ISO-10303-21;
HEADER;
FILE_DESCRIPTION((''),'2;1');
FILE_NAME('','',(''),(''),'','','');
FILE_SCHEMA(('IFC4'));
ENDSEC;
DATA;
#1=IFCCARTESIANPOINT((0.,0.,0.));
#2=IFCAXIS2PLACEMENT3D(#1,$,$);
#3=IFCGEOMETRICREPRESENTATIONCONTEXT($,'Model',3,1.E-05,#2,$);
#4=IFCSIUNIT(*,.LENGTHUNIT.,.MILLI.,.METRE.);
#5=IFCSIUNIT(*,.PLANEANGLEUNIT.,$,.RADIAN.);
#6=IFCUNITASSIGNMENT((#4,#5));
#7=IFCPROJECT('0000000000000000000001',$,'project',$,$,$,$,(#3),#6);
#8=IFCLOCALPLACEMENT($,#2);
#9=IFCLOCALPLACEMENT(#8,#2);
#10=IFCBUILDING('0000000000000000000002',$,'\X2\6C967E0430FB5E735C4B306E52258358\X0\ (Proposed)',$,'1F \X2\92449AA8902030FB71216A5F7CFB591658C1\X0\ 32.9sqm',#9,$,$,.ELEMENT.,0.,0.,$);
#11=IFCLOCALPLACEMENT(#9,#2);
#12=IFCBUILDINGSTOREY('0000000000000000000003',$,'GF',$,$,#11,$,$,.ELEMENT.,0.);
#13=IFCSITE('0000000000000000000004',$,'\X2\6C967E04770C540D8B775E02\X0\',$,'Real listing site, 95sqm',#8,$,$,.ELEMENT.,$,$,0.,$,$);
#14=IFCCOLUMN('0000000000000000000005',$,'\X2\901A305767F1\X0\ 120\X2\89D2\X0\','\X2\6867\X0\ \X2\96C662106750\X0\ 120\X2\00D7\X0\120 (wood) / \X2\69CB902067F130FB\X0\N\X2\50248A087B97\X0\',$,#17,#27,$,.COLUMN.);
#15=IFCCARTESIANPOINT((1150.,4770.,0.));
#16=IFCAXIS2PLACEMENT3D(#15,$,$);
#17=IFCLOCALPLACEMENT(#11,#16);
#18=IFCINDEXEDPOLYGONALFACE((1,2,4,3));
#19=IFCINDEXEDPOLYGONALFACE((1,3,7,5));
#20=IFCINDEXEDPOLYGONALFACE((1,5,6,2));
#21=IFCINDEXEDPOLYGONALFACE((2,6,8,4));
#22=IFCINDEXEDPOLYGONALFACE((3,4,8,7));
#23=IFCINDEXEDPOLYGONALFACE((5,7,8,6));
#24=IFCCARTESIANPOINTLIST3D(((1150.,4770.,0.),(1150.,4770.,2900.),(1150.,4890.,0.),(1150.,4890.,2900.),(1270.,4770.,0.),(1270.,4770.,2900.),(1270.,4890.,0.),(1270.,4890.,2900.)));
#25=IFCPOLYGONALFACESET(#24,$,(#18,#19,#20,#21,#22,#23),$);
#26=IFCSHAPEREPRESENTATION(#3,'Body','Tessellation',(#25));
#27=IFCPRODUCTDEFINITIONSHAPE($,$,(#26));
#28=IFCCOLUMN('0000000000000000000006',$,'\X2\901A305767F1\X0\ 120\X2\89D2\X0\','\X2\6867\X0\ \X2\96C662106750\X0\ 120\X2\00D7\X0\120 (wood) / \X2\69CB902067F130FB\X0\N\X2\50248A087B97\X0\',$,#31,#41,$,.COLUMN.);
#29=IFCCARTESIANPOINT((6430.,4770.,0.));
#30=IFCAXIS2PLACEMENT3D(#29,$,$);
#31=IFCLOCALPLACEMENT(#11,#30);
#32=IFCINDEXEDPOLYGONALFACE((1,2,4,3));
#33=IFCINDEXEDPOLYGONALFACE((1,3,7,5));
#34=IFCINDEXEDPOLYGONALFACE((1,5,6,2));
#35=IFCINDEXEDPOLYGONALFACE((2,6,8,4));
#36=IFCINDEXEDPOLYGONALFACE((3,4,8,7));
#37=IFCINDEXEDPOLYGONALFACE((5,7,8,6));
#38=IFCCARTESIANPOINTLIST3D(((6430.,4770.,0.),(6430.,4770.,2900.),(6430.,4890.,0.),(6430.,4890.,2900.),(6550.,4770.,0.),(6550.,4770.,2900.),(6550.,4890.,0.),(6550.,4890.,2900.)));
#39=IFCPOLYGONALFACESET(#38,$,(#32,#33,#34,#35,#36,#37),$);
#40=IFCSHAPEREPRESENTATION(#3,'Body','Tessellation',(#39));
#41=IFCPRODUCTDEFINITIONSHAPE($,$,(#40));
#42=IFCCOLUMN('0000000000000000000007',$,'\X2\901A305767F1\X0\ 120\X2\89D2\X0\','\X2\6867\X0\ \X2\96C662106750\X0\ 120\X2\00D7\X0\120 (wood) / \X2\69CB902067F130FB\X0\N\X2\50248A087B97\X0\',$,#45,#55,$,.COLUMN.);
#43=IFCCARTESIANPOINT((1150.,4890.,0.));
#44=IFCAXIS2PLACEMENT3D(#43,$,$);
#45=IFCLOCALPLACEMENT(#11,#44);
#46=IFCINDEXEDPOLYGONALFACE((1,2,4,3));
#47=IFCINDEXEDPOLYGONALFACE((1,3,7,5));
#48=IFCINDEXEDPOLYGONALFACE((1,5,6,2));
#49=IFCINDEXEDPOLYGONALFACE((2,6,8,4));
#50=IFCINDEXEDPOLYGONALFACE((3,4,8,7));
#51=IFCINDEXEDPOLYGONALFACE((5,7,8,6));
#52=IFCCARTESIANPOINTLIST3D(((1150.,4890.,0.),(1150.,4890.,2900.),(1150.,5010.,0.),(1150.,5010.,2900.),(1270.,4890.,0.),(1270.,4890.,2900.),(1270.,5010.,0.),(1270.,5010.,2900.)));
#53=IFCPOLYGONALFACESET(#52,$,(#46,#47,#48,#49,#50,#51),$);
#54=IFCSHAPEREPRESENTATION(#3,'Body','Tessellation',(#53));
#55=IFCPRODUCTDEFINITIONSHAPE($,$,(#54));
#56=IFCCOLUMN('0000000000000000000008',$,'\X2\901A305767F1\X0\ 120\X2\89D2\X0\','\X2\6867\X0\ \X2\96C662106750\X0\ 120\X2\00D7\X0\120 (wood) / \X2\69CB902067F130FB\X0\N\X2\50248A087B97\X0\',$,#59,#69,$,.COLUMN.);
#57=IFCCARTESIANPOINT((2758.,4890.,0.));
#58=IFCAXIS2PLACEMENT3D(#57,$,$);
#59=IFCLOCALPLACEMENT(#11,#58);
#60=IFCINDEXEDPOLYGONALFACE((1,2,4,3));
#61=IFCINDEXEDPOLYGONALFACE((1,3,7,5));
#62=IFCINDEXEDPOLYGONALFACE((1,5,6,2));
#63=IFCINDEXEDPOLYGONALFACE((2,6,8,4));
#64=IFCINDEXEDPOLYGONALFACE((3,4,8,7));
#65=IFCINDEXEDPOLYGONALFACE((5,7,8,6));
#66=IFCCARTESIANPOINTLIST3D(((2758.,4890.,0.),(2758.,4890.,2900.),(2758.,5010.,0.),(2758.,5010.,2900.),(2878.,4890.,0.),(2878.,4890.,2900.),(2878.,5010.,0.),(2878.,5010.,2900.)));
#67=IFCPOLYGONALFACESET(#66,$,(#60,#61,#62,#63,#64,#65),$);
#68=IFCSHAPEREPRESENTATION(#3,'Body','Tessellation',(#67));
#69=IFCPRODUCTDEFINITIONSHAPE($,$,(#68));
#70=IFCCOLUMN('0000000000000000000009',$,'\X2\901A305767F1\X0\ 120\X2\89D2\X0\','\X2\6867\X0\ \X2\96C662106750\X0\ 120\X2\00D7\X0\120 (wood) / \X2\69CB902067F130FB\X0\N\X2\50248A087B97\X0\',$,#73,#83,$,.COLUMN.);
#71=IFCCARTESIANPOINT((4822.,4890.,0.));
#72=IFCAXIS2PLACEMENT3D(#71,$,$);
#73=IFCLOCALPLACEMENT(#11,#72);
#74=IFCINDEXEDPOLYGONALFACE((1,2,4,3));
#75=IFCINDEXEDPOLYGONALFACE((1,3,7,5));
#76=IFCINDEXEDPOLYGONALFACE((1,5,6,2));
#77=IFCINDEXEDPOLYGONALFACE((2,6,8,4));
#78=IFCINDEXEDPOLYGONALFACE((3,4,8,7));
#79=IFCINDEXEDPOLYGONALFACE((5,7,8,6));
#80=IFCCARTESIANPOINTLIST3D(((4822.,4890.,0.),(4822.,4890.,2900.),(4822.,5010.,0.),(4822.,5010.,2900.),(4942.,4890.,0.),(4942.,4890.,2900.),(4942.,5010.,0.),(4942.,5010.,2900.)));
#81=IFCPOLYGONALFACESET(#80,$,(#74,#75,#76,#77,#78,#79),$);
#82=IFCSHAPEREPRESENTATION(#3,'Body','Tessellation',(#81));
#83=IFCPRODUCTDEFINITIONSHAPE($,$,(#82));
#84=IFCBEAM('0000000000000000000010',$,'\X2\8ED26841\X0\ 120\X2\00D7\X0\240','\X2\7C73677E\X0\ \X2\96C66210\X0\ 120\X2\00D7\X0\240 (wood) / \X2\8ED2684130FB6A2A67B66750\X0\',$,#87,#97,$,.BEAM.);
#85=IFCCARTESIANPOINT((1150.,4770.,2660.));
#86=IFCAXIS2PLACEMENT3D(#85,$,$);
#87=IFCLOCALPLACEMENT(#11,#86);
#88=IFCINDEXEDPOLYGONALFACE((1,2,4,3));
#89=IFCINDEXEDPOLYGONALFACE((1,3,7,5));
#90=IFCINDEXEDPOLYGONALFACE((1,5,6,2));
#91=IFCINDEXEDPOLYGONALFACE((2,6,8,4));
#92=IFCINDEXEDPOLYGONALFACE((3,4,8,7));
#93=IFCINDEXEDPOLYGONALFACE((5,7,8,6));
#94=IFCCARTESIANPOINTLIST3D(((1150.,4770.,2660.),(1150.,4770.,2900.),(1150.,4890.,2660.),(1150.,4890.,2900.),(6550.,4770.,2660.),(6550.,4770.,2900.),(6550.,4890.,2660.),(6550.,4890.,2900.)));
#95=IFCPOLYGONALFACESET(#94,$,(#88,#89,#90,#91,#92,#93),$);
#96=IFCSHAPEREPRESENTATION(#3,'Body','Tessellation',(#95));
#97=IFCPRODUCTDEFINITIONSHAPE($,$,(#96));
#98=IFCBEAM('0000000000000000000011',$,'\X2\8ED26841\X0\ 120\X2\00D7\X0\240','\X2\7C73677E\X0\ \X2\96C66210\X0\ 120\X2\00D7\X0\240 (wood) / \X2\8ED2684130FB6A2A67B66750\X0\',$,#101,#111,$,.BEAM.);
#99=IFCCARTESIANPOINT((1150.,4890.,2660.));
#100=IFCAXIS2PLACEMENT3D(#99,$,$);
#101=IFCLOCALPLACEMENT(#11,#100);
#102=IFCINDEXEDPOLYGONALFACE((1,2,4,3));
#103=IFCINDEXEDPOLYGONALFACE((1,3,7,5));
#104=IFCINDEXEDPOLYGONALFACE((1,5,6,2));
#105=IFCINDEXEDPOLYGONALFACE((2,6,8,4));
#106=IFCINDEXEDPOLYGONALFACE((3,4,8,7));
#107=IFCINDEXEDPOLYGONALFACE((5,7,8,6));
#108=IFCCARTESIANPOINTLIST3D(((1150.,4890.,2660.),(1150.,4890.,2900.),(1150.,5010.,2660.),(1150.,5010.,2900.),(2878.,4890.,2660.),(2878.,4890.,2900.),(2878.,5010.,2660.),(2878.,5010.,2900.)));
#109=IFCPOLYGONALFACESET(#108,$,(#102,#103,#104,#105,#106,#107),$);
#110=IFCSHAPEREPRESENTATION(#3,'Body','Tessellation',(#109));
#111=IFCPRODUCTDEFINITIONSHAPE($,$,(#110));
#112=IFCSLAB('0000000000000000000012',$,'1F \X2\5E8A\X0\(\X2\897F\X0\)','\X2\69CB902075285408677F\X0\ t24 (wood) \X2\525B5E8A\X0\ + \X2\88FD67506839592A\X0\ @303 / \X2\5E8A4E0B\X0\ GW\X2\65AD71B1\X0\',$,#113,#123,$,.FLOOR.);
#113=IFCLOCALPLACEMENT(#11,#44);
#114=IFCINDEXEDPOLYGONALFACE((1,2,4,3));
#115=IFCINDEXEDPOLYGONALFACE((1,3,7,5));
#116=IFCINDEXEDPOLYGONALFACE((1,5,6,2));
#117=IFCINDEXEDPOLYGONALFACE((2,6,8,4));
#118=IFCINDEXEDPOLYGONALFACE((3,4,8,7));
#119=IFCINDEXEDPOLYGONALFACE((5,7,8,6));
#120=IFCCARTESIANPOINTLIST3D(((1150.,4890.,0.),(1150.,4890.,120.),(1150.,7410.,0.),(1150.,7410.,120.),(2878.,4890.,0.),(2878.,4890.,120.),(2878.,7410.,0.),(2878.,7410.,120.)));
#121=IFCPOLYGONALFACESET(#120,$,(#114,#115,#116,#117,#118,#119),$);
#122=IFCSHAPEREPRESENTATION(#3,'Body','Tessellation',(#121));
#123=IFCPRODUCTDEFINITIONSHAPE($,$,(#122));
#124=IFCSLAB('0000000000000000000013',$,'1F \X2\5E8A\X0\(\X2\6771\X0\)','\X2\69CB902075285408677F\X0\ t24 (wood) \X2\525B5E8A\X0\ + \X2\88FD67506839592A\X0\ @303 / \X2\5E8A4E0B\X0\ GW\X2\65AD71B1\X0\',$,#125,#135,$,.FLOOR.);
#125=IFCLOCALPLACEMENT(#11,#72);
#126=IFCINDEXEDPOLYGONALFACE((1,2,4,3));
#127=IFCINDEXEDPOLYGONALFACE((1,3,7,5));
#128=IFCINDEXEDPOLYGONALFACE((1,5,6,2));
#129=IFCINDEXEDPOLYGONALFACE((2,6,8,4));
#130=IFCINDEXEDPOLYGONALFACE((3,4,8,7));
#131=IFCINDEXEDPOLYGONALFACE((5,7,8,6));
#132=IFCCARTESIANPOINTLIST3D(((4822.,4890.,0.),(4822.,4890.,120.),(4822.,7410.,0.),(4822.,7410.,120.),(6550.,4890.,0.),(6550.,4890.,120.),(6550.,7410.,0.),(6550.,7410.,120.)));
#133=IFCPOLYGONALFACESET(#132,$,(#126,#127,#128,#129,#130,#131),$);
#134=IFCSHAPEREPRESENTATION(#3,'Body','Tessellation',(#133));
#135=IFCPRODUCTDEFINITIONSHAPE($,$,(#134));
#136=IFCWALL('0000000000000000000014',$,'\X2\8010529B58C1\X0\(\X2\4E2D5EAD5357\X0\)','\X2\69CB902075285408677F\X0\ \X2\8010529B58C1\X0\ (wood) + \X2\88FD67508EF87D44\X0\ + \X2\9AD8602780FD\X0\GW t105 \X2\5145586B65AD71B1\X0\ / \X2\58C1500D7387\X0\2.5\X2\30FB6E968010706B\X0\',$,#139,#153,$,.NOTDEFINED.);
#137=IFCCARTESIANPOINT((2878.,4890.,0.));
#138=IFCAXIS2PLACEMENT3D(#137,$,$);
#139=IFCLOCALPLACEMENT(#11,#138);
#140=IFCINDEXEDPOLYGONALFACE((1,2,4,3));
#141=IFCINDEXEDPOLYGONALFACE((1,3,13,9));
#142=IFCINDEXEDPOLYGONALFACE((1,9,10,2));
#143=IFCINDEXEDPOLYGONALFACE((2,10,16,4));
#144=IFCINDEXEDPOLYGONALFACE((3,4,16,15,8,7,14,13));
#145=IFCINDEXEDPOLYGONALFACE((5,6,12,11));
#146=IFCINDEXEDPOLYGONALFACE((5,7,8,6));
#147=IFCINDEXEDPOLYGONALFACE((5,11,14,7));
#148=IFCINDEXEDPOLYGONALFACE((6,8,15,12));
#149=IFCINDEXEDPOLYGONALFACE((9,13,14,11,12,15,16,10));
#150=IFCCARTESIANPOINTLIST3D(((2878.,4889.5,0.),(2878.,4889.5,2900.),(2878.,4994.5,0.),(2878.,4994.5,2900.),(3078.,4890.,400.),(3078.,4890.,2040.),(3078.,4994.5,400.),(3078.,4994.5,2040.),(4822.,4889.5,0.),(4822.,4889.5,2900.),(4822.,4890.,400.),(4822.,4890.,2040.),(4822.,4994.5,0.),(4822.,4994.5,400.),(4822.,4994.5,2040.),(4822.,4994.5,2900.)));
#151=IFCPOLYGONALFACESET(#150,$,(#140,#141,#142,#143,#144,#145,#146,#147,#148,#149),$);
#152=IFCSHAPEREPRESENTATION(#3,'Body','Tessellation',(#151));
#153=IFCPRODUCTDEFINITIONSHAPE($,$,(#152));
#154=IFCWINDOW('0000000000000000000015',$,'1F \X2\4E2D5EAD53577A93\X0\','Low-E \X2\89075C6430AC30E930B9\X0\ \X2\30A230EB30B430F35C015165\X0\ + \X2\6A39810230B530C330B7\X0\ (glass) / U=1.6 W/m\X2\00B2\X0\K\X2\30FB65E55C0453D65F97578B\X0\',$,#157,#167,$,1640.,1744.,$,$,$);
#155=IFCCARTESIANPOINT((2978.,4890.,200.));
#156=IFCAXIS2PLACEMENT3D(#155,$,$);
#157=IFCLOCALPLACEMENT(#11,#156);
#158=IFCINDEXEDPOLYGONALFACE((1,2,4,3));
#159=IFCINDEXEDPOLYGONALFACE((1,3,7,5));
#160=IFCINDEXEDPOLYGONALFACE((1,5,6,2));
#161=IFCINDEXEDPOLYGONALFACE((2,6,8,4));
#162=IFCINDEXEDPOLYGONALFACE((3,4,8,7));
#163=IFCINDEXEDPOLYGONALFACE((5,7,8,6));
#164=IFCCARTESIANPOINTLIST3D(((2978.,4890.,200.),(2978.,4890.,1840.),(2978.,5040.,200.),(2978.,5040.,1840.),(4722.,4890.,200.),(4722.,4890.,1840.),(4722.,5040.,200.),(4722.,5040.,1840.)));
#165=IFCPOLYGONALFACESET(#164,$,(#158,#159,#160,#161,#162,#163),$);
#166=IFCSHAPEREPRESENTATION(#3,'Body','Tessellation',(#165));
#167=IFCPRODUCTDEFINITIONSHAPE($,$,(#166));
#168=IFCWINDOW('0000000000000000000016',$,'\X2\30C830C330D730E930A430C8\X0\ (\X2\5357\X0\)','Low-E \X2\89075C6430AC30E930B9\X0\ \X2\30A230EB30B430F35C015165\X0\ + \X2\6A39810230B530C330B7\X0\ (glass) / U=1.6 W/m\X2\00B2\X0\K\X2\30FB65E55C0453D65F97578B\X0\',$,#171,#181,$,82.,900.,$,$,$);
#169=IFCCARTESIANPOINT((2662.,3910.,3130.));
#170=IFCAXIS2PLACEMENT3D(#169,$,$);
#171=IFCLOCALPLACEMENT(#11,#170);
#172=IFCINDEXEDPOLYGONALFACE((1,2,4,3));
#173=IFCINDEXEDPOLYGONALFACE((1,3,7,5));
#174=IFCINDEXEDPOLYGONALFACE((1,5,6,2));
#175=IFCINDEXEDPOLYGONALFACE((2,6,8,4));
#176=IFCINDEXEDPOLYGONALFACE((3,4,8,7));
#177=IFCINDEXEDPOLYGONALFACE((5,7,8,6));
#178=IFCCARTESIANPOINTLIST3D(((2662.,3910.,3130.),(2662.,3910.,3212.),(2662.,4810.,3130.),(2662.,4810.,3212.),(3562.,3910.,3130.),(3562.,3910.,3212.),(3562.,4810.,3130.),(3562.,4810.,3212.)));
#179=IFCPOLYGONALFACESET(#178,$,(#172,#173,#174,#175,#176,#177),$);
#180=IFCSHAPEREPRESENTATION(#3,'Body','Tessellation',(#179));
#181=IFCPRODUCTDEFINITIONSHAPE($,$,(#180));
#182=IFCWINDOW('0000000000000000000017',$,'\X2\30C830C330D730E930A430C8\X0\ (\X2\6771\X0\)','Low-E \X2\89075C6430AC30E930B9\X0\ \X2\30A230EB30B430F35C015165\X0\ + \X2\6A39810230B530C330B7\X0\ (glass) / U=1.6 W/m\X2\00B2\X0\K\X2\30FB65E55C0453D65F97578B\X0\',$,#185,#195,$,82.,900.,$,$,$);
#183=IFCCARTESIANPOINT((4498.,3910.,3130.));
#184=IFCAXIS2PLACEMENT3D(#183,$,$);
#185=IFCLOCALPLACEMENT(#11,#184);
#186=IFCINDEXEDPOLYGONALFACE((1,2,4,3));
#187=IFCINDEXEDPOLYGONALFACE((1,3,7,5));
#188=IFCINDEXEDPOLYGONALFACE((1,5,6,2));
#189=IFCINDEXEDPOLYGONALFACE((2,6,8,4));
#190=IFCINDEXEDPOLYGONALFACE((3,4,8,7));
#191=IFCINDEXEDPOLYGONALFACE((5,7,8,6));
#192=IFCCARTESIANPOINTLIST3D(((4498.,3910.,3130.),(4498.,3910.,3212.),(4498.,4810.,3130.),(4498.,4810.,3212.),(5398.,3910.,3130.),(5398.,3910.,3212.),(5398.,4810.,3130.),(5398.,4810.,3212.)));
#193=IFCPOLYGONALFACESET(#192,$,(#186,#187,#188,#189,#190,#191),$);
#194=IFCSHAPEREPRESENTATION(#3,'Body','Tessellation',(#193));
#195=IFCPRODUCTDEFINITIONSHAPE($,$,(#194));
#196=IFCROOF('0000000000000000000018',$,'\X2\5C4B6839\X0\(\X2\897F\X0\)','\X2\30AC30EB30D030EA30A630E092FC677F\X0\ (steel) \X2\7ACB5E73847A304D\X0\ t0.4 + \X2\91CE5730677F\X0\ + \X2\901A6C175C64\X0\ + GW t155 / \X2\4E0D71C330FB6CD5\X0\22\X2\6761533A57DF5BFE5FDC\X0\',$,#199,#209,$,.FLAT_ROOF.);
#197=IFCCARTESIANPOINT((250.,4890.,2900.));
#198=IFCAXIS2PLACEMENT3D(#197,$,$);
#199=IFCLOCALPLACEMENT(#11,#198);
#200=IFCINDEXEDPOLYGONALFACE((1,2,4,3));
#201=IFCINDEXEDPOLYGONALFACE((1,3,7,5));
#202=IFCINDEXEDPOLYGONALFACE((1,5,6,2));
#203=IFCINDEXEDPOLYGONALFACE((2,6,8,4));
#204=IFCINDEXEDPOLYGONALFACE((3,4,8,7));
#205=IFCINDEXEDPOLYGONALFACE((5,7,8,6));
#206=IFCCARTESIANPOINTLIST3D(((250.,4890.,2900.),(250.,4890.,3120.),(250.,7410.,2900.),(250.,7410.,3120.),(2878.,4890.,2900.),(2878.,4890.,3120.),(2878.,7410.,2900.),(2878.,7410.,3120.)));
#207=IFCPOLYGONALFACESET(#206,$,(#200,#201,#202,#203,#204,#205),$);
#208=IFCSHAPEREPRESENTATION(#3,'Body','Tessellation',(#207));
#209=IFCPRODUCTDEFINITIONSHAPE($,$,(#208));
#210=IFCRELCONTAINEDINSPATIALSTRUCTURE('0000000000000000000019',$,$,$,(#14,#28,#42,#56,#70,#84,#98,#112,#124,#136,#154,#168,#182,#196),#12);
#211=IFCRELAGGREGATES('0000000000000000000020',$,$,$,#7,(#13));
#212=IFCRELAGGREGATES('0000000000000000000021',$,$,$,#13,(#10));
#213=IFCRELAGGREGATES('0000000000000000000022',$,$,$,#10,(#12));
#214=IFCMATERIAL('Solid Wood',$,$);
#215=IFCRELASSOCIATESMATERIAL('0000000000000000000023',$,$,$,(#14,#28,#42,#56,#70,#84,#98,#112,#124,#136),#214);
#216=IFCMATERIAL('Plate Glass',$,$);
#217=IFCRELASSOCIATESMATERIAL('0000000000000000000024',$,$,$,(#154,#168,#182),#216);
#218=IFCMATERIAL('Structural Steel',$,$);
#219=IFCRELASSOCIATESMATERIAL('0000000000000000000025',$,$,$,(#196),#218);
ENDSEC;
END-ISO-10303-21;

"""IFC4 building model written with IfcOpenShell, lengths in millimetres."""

from ifc_helpers import new_model, si_unit, frame, frame_2d, origin, place, context, project, spatial, rectangle, extrude, material, element, fill, save


model = new_model("IFC4")

# Units and contexts
model_context = context("Model", 3, precision=1e-05, world=origin())
ifc_project = project(units=[si_unit("LENGTHUNIT", "METRE", prefix="MILLI"), si_unit("PLANEANGLEUNIT", "RADIAN")], contexts=[model_context])

# Site, building, storey
site_placement = place(None, origin())
site = spatial("IfcSite", under=ifc_project, at=site_placement, Name="沖縄県名護市", ObjectType="Real listing site, 95sqm", CompositionType="ELEMENT", RefElevation=0.0)
building_placement = place(site_placement, origin())
building = spatial("IfcBuilding", under=site, at=building_placement, Name="沖縄・平屋の別荘 (Proposed)", ObjectType="1F 鉄骨造・無機系外壁 32.9sqm", CompositionType="ELEMENT", ElevationOfRefHeight=0.0, ElevationOfTerrain=0.0)
storey_placement = place(building_placement, origin())
storey = spatial("IfcBuildingStorey", under=building, at=storey_placement, Name="GF", CompositionType="ELEMENT", Elevation=0.0)

# Columns
ifc_material_1 = material(Name="Solid Wood")
column_1_placement = place(storey_placement, frame((1150.0, 4770.0, 0.0)))
element("IfcColumn", 1, at=column_1_placement, inside=storey, material=ifc_material_1, Name="通し柱 120角", Description="桧 集成材 120×120 (wood) / 構造柱・N値計算", PredefinedType="COLUMN", context=model_context, shape_type="SweptSolid", body=[
    extrude(rectangle(XDim=120.0, YDim=120.0, at=frame_2d((60.0, 60.0))), frame((1150.0, 4770.0, 0.0)), (0.0, 0.0, 1.0), 2900.0),
])
column_2_placement = place(storey_placement, frame((6430.0, 4770.0, 0.0)))
element("IfcColumn", 2, at=column_2_placement, inside=storey, material=ifc_material_1, Name="通し柱 120角", Description="桧 集成材 120×120 (wood) / 構造柱・N値計算", PredefinedType="COLUMN", context=model_context, shape_type="SweptSolid", body=[
    extrude(rectangle(XDim=120.0, YDim=120.0, at=frame_2d((60.0, 60.0))), frame((6430.0, 4770.0, 0.0)), (0.0, 0.0, 1.0), 2900.0),
])
column_3_placement = place(storey_placement, frame((1150.0, 4890.0, 0.0)))
element("IfcColumn", 3, at=column_3_placement, inside=storey, material=ifc_material_1, Name="通し柱 120角", Description="桧 集成材 120×120 (wood) / 構造柱・N値計算", PredefinedType="COLUMN", context=model_context, shape_type="SweptSolid", body=[
    extrude(rectangle(XDim=120.0, YDim=120.0, at=frame_2d((60.0, 60.0))), frame((1150.0, 4890.0, 0.0)), (0.0, 0.0, 1.0), 2900.0),
])
column_4_placement = place(storey_placement, frame((2758.0, 4890.0, 0.0)))
element("IfcColumn", 4, at=column_4_placement, inside=storey, material=ifc_material_1, Name="通し柱 120角", Description="桧 集成材 120×120 (wood) / 構造柱・N値計算", PredefinedType="COLUMN", context=model_context, shape_type="SweptSolid", body=[
    extrude(rectangle(XDim=120.0, YDim=120.0, at=frame_2d((60.0, 60.0))), frame((2758.0, 4890.0, 0.0)), (0.0, 0.0, 1.0), 2900.0),
])
column_5_placement = place(storey_placement, frame((4822.0, 4890.0, 0.0)))
element("IfcColumn", 5, at=column_5_placement, inside=storey, material=ifc_material_1, Name="通し柱 120角", Description="桧 集成材 120×120 (wood) / 構造柱・N値計算", PredefinedType="COLUMN", context=model_context, shape_type="SweptSolid", body=[
    extrude(rectangle(XDim=120.0, YDim=120.0, at=frame_2d((60.0, 60.0))), frame((4822.0, 4890.0, 0.0)), (0.0, 0.0, 1.0), 2900.0),
])

# Beams
beam_1_placement = place(storey_placement, frame((1150.0, 4770.0, 2660.0)))
element("IfcBeam", 6, at=beam_1_placement, inside=storey, material=ifc_material_1, Name="軒桁 120×240", Description="米松 集成 120×240 (wood) / 軒桁・横架材", PredefinedType="BEAM", context=model_context, shape_type="SweptSolid", body=[
    extrude(rectangle(XDim=5400.0, YDim=120.0, at=frame_2d((2700.0, 60.0))), frame((1150.0, 4770.0, 2660.0)), (0.0, 0.0, 1.0), 240.0),
])
beam_2_placement = place(storey_placement, frame((1150.0, 4890.0, 2660.0)))
element("IfcBeam", 7, at=beam_2_placement, inside=storey, material=ifc_material_1, Name="軒桁 120×240", Description="米松 集成 120×240 (wood) / 軒桁・横架材", PredefinedType="BEAM", context=model_context, shape_type="SweptSolid", body=[
    extrude(rectangle(XDim=1728.0, YDim=120.0, at=frame_2d((864.0, 60.0))), frame((1150.0, 4890.0, 2660.0)), (0.0, 0.0, 1.0), 240.0),
])

# Slabs
slab_1_placement = place(storey_placement, frame((1150.0, 4890.0, 0.0)))
element("IfcSlab", 8, at=slab_1_placement, inside=storey, material=ifc_material_1, Name="1F 床(西)", Description="構造用合板 t24 (wood) 剛床 + 製材根太 @303 / 床下 GW断熱", PredefinedType="FLOOR", context=model_context, shape_type="SweptSolid", body=[
    extrude(rectangle(XDim=1728.0, YDim=2520.0, at=frame_2d((864.0, 1260.0))), frame((1150.0, 4890.0, 0.0)), (0.0, 0.0, 1.0), 120.0),
])
slab_2_placement = place(storey_placement, frame((4822.0, 4890.0, 0.0)))
element("IfcSlab", 9, at=slab_2_placement, inside=storey, material=ifc_material_1, Name="1F 床(東)", Description="構造用合板 t24 (wood) 剛床 + 製材根太 @303 / 床下 GW断熱", PredefinedType="FLOOR", context=model_context, shape_type="SweptSolid", body=[
    extrude(rectangle(XDim=1728.0, YDim=2520.0, at=frame_2d((864.0, 1260.0))), frame((4822.0, 4890.0, 0.0)), (0.0, 0.0, 1.0), 120.0),
])

# Wall, opening, window
wall_1_placement = place(storey_placement, frame((2878.0, 4890.0, 0.0)))
wall_1 = element("IfcWall", 10, at=wall_1_placement, inside=storey, material=ifc_material_1, Name="耐力壁(中庭南)", Description="構造用合板 耐力壁 (wood) + 製材軸組 + 高性能GW t105 充填断熱 / 壁倍率2.5・準耐火", PredefinedType="NOTDEFINED", context=model_context, shape_type="SweptSolid", body=[
    extrude(rectangle(XDim=1944.0, YDim=105.0, at=frame_2d((972.0, 52.0))), frame((2878.0, 4890.0, 0.0)), (0.0, 0.0, 1.0), 2900.0),
])
opening_placement = place(storey_placement, frame((2978.0, 4890.0, 200.0)))
opening = element("IfcOpeningElement", 11, at=opening_placement, cuts=wall_1, PredefinedType="NOTDEFINED", context=model_context, shape_type="SweptSolid", body=[
    extrude(rectangle(XDim=1744.0, YDim=150.0, at=frame_2d((872.0, 75.0))), frame((2978.0, 4890.0, 200.0)), (0.0, 0.0, 1.0), 1640.0),
])
ifc_material_2 = material(Name="Plate Glass")
window_1_placement = place(storey_placement, frame((2978.0, 4890.0, 200.0)))
window_1 = element("IfcWindow", 12, at=window_1_placement, inside=storey, material=ifc_material_2, Name="1F 中庭南窓", Description="Low-E 複層ガラス アルゴン封入 + 樹脂サッシ (glass) / U=1.6 W/m²K・日射取得型", OverallHeight=1640.0, OverallWidth=1744.0, context=model_context, shape_type="SweptSolid", body=[
    extrude(rectangle(XDim=1744.0, YDim=150.0, at=frame_2d((872.0, 75.0))), frame((2978.0, 4890.0, 200.0)), (0.0, 0.0, 1.0), 1640.0),
])
fill(opening, window_1)

# Windows
window_2_placement = place(storey_placement, frame((2662.0, 3910.0, 3130.0)))
element("IfcWindow", 13, at=window_2_placement, inside=storey, material=ifc_material_2, Name="トップライト (南)", Description="Low-E 複層ガラス アルゴン封入 + 樹脂サッシ (glass) / U=1.6 W/m²K・日射取得型", OverallHeight=82.0, OverallWidth=900.0, context=model_context, shape_type="SweptSolid", body=[
    extrude(rectangle(XDim=900.0, YDim=900.0, at=frame_2d((450.0, 450.0))), frame((2662.0, 3910.0, 3130.0)), (0.0, 0.0, 1.0), 82.0),
])
window_3_placement = place(storey_placement, frame((4498.0, 3910.0, 3130.0)))
element("IfcWindow", 14, at=window_3_placement, inside=storey, material=ifc_material_2, Name="トップライト (東)", Description="Low-E 複層ガラス アルゴン封入 + 樹脂サッシ (glass) / U=1.6 W/m²K・日射取得型", OverallHeight=82.0, OverallWidth=900.0, context=model_context, shape_type="SweptSolid", body=[
    extrude(rectangle(XDim=900.0, YDim=900.0, at=frame_2d((450.0, 450.0))), frame((4498.0, 3910.0, 3130.0)), (0.0, 0.0, 1.0), 82.0),
])

# Roof
ifc_material_3 = material(Name="Structural Steel")
roof_1_placement = place(storey_placement, frame((250.0, 4890.0, 2900.0)))
element("IfcRoof", 15, at=roof_1_placement, inside=storey, material=ifc_material_3, Name="屋根(西)", Description="ガルバリウム鋼板 (steel) 立平葺き t0.4 + 野地板 + 通気層 + GW t155 / 不燃・法22条区域対応", PredefinedType="FLAT_ROOF", context=model_context, shape_type="SweptSolid", body=[
    extrude(rectangle(XDim=2628.0, YDim=2520.0, at=frame_2d((1314.0, 1260.0))), frame((250.0, 4890.0, 2900.0)), (0.0, 0.0, 1.0), 220.0),
])

save(model, "model.ifc")
